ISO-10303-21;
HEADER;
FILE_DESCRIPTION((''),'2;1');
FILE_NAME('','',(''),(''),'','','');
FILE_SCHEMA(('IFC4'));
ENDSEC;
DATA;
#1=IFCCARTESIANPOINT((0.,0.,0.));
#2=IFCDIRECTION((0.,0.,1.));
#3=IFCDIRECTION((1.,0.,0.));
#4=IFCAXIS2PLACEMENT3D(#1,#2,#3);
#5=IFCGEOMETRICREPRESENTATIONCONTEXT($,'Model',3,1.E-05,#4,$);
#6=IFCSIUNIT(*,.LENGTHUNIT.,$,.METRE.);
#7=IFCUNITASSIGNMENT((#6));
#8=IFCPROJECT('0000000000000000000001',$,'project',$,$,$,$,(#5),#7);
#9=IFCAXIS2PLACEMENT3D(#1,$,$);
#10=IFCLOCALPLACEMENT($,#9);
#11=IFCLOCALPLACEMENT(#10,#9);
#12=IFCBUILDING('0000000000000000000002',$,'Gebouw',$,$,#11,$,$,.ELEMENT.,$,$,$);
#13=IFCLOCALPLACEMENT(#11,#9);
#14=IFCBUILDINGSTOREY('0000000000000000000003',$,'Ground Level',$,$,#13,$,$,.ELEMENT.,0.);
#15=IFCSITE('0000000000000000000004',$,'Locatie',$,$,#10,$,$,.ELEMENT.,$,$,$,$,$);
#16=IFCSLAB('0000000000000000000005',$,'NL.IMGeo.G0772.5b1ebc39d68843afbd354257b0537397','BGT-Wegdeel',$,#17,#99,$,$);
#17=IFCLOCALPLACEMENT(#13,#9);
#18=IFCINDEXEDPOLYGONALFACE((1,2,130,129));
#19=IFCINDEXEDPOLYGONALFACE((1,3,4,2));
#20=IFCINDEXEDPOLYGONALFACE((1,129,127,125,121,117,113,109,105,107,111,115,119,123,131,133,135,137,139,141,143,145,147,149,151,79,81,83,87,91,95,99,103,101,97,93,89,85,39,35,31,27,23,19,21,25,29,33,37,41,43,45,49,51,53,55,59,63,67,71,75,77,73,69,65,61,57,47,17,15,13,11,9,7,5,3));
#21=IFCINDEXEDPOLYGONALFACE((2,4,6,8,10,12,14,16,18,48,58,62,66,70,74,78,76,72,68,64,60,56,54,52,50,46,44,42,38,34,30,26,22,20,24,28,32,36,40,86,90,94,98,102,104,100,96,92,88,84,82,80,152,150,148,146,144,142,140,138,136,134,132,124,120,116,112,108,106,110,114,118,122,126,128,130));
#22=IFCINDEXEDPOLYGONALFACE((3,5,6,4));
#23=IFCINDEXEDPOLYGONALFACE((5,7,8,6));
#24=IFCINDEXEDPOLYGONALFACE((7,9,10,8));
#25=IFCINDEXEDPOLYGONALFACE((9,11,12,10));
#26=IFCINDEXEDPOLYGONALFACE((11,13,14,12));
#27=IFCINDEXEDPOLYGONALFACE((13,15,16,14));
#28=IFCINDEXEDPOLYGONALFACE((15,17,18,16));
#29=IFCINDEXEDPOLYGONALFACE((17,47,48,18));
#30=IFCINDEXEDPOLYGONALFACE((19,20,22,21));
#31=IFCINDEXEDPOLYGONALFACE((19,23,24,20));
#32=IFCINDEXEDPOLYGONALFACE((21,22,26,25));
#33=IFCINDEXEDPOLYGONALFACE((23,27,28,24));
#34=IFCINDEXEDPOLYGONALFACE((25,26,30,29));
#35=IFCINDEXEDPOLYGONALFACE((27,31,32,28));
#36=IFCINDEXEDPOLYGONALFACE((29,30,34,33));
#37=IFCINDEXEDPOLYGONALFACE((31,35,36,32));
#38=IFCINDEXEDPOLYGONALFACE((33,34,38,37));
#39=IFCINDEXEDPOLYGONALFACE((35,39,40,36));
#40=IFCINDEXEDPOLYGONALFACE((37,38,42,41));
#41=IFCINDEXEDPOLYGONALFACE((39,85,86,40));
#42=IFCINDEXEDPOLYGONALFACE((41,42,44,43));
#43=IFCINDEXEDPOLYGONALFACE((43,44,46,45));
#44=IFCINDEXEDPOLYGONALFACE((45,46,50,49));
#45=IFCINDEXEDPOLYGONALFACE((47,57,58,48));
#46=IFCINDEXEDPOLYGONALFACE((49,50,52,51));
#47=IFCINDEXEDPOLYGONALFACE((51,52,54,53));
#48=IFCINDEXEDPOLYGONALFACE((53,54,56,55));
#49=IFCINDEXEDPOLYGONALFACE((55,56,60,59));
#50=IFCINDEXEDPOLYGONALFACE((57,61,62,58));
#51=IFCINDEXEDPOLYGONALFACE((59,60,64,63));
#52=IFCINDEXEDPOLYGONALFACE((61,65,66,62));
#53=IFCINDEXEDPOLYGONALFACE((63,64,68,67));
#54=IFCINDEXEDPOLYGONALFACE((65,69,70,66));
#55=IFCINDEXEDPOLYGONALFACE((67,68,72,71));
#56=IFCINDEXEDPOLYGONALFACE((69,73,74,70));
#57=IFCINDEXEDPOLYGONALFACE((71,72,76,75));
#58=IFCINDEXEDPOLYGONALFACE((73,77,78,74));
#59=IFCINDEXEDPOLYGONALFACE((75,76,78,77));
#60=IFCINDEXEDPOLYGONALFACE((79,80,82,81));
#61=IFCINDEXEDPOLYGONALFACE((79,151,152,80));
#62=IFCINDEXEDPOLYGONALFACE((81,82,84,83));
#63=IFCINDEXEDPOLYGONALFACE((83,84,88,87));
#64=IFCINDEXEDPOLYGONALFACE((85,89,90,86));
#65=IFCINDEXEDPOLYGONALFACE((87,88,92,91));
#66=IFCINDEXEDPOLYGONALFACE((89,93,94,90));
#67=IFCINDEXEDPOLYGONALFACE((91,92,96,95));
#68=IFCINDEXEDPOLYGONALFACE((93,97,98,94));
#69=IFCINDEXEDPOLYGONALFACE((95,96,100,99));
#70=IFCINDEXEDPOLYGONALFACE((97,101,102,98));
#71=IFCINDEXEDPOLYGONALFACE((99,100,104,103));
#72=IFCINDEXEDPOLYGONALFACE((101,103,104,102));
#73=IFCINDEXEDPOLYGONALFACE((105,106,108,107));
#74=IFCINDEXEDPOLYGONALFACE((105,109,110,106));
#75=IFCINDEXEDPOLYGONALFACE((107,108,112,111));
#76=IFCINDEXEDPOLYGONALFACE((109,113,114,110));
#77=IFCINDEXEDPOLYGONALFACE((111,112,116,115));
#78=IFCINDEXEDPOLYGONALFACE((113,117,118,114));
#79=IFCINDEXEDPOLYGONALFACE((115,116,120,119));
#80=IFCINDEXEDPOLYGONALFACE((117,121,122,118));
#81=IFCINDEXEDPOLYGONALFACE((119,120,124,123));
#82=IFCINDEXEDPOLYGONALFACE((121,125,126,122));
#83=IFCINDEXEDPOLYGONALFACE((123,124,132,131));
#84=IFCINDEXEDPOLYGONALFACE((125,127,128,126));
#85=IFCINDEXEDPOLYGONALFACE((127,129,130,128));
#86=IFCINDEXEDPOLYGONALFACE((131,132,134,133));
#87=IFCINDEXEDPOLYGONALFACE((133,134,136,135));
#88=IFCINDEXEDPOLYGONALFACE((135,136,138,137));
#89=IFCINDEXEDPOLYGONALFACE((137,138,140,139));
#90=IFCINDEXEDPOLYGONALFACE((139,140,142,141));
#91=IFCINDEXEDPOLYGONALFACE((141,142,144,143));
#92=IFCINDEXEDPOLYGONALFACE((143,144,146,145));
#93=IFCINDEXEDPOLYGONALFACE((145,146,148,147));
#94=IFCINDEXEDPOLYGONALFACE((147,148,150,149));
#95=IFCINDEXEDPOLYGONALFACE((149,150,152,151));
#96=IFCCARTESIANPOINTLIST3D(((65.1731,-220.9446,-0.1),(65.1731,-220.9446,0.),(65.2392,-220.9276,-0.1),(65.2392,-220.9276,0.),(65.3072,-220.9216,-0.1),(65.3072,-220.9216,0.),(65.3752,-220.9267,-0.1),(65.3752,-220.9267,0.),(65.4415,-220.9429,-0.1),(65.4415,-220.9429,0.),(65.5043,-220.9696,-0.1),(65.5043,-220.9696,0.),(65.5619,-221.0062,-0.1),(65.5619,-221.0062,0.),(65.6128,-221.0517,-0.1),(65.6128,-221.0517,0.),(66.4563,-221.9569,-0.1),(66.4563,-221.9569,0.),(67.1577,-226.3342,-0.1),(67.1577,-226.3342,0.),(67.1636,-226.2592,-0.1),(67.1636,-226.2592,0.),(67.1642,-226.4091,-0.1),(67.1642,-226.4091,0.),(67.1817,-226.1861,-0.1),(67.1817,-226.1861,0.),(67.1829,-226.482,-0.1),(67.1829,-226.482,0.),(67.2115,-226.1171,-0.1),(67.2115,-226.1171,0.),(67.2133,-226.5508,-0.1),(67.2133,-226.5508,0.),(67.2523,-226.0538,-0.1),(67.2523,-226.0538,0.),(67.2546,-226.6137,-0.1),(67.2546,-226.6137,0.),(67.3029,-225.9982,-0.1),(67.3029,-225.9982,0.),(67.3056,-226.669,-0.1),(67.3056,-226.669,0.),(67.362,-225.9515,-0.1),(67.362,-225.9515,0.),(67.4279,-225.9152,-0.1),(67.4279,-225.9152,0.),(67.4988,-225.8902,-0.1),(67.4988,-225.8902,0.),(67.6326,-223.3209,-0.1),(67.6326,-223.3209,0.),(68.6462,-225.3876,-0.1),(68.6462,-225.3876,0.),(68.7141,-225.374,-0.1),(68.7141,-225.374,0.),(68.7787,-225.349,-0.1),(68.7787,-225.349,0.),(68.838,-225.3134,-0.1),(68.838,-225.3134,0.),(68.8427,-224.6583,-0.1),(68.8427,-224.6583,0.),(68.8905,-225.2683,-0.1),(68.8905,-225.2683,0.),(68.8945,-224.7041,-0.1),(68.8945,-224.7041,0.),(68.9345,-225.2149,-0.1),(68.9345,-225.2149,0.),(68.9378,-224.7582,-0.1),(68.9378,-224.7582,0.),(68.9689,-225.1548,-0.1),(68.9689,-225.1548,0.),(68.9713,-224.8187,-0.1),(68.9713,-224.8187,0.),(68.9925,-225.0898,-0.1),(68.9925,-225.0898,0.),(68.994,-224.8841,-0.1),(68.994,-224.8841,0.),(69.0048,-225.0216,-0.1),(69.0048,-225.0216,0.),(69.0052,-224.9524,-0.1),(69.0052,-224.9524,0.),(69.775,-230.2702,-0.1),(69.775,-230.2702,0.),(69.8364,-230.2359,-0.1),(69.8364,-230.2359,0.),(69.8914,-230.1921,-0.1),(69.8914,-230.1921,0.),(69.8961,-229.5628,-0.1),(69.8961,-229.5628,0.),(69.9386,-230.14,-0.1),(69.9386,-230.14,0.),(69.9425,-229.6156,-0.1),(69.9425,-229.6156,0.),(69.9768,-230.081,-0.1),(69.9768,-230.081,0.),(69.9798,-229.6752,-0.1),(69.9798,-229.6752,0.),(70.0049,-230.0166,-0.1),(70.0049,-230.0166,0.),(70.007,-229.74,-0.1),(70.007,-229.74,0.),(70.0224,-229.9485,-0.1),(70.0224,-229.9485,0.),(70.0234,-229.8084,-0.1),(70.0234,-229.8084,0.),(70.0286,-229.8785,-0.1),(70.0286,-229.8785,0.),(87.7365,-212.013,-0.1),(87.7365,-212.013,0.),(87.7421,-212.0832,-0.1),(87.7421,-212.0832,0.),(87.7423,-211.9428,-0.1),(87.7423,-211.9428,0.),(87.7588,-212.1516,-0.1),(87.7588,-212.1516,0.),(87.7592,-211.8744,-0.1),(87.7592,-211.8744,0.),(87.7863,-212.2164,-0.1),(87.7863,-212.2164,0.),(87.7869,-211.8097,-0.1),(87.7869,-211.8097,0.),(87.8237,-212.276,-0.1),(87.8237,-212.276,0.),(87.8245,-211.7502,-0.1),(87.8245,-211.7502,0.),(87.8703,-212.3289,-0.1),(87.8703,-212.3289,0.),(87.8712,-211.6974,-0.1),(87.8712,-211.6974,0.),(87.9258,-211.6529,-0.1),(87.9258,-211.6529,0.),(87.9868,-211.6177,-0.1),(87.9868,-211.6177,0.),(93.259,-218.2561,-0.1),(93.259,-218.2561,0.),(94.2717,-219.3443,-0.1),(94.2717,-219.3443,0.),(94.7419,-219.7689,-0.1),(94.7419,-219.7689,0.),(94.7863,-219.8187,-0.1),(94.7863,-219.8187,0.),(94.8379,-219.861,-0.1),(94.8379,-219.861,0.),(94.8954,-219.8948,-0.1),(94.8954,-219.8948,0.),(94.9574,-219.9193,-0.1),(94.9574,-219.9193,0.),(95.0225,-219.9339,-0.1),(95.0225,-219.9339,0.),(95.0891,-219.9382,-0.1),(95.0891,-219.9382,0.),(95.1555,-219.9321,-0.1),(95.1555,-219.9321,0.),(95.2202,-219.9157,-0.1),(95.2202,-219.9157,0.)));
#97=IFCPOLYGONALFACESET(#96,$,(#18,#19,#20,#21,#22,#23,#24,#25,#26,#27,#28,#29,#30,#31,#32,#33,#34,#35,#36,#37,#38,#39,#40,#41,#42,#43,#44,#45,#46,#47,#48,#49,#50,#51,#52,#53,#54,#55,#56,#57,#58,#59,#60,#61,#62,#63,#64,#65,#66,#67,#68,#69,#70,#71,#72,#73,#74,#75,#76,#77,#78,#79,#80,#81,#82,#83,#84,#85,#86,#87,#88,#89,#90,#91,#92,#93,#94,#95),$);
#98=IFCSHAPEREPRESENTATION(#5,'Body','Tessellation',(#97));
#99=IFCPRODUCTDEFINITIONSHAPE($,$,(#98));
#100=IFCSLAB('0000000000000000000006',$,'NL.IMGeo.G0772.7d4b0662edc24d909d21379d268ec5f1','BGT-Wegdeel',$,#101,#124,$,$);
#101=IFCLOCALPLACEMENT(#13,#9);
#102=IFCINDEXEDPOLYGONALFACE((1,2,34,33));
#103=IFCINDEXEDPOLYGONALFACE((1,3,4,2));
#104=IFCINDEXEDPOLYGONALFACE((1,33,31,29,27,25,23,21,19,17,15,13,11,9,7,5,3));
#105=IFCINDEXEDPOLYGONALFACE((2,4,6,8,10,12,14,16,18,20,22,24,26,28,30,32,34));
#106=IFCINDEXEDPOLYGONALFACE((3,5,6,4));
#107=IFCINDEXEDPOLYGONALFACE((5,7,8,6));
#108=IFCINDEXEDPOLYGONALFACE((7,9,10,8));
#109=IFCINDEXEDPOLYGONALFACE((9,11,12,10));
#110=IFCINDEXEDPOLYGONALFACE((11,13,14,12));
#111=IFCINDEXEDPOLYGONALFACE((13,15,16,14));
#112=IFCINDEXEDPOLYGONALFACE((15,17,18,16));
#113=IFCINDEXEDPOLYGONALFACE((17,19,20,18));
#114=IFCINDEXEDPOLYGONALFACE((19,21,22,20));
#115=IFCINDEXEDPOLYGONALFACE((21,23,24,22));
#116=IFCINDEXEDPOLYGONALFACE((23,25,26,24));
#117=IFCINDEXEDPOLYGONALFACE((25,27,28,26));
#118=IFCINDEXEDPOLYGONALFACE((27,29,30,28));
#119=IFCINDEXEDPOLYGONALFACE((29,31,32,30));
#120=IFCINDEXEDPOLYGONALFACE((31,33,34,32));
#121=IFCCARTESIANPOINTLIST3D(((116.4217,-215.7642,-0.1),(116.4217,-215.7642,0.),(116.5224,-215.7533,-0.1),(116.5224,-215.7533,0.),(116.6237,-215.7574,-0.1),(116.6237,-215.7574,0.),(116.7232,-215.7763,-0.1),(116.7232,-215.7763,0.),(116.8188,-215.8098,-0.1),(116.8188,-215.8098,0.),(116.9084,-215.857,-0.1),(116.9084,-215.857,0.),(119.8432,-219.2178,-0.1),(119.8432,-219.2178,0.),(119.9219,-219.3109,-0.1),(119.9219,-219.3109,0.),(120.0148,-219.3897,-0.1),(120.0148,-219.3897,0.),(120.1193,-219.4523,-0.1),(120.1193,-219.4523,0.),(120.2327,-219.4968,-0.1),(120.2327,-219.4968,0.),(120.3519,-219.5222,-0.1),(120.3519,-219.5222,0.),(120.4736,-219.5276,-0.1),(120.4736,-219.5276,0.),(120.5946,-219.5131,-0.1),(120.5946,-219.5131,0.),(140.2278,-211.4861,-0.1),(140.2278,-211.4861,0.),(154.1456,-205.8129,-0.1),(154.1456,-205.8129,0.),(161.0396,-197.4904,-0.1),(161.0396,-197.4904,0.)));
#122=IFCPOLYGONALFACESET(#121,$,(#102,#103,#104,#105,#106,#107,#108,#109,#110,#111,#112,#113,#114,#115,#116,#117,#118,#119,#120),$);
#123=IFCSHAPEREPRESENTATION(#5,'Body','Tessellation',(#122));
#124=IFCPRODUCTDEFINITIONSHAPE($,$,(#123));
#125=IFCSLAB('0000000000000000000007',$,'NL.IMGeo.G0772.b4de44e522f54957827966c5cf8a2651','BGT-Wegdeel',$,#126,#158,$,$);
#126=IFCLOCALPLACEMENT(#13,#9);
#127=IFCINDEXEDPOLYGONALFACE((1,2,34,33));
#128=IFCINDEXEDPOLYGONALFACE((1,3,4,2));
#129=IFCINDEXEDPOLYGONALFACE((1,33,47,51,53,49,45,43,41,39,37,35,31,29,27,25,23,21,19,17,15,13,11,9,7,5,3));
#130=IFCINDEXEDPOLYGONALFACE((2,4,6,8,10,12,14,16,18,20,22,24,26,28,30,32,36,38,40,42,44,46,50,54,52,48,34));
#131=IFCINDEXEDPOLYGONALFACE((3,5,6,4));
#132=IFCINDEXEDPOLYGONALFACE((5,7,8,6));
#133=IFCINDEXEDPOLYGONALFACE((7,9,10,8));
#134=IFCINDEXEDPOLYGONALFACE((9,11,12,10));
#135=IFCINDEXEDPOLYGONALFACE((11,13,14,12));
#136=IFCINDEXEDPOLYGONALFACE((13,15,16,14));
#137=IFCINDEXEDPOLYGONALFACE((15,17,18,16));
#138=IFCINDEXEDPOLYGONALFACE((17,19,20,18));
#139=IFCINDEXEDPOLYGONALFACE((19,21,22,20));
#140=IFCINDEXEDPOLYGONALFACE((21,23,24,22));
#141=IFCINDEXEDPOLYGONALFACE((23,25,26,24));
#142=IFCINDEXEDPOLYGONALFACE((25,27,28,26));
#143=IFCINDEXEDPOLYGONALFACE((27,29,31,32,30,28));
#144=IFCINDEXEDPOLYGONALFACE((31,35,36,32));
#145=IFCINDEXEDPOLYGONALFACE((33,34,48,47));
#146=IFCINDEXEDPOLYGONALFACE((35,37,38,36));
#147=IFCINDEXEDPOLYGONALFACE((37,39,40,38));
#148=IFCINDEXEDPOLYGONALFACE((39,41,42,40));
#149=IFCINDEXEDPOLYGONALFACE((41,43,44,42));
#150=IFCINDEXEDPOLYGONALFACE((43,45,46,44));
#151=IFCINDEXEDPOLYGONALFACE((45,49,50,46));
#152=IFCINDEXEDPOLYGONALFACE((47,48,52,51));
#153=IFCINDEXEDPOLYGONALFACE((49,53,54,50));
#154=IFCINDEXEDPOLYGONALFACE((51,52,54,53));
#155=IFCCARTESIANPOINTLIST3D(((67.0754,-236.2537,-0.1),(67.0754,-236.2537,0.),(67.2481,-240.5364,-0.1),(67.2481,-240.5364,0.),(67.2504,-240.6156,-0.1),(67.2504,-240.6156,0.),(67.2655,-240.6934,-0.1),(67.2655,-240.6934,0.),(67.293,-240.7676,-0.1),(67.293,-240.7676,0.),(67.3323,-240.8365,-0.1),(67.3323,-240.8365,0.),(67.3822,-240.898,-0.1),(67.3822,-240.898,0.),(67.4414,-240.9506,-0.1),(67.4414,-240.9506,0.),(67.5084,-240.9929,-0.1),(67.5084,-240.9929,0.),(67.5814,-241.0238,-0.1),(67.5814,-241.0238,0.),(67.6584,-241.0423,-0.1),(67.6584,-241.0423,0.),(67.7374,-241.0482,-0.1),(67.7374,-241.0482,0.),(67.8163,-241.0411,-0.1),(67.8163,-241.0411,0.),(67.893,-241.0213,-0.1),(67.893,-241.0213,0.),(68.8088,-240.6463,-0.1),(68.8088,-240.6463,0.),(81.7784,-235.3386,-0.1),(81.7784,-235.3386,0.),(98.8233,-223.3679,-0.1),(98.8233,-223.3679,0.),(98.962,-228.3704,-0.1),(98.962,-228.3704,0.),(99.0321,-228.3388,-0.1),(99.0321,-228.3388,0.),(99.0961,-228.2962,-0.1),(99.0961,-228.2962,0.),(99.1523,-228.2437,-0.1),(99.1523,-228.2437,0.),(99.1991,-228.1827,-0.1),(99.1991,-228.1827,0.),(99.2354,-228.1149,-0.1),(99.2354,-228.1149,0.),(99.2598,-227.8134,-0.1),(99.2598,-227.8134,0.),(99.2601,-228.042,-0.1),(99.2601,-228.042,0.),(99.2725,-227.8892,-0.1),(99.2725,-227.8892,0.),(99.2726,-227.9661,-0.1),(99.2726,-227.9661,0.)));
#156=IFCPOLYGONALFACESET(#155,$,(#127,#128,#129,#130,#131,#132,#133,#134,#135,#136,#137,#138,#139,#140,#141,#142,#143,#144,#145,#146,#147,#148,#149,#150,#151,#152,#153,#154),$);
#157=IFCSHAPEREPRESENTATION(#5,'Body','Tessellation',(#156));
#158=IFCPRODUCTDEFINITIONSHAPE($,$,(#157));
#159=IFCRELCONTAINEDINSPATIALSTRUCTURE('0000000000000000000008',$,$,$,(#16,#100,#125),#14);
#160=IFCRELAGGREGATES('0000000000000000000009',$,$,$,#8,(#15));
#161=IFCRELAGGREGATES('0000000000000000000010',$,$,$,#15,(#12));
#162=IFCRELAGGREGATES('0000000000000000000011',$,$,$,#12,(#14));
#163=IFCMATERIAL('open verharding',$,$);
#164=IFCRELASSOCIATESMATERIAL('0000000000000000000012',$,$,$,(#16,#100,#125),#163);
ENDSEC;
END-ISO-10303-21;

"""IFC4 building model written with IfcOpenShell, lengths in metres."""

from ifc_helpers import new_model, si_unit, frame, origin, origin_with_axes, place, context, project, spatial, polyline, outline, extrude, material, element, save


model = new_model("IFC4")

# Units and contexts
model_context = context("Model", 3, precision=1e-05, world=origin_with_axes())
ifc_project = project(units=[si_unit("LENGTHUNIT", "METRE")], contexts=[model_context])

# Site, building, storey
site_placement = place(None, origin())
site = spatial("IfcSite", under=ifc_project, at=site_placement, Name="Locatie", CompositionType="ELEMENT")
building_placement = place(site_placement, origin())
building = spatial("IfcBuilding", under=site, at=building_placement, Name="Gebouw", CompositionType="ELEMENT")
storey_placement = place(building_placement, origin())
storey = spatial("IfcBuildingStorey", under=building, at=storey_placement, Name="Ground Level", CompositionType="ELEMENT", Elevation=0.0)

# Slabs
ifc_material_1 = material(Name="open verharding")
slab_1_placement = place(storey_placement, origin())
element("IfcSlab", 1, at=slab_1_placement, inside=storey, material=ifc_material_1, Name="NL.IMGeo.G0772.5b1ebc39d68843afbd354257b0537397", Description="BGT-Wegdeel", context=model_context, shape_type="SweptSolid", body=[
    extrude(outline(polyline([(87.9868, -211.6177), (87.9258, -211.6529), (87.8712, -211.6974), (87.8245, -211.7502), (87.7869, -211.8097), (87.7592, -211.8744), (87.7423, -211.9428), (87.7365, -212.013), (87.7421, -212.0832), (87.7588, -212.1516), (87.7863, -212.2164), (87.8237, -212.276), (87.8703, -212.3289), (93.259, -218.2561), (94.2717, -219.3443), (94.7419, -219.7689), (94.7863, -219.8187), (94.8379, -219.861), (94.8954, -219.8948), (94.9574, -219.9193), (95.0225, -219.9339), (95.0891, -219.9382), (95.1555, -219.9321), (95.2202, -219.9157), (69.775, -230.2702), (69.8364, -230.2359), (69.8914, -230.1921), (69.9386, -230.14), (69.9768, -230.081), (70.0049, -230.0166), (70.0224, -229.9485), (70.0286, -229.8785), (70.0234, -229.8084), (70.007, -229.74), (69.9798, -229.6752), (69.9425, -229.6156), (69.8961, -229.5628), (67.3056, -226.669), (67.2546, -226.6137), (67.2133, -226.5508), (67.1829, -226.482), (67.1642, -226.4091), (67.1577, -226.3342), (67.1636, -226.2592), (67.1817, -226.1861), (67.2115, -226.1171), (67.2523, -226.0538), (67.3029, -225.9982), (67.362, -225.9515), (67.4279, -225.9152), (67.4988, -225.8902), (68.6462, -225.3876), (68.7141, -225.374), (68.7787, -225.349), (68.838, -225.3134), (68.8905, -225.2683), (68.9345, -225.2149), (68.9689, -225.1548), (68.9925, -225.0898), (69.0048, -225.0216), (69.0052, -224.9524), (68.994, -224.8841), (68.9713, -224.8187), (68.9378, -224.7582), (68.8945, -224.7041), (68.8427, -224.6583), (67.6326, -223.3209), (66.4563, -221.9569), (65.6128, -221.0517), (65.5619, -221.0062), (65.5043, -220.9696), (65.4415, -220.9429), (65.3752, -220.9267), (65.3072, -220.9216), (65.2392, -220.9276), (65.1731, -220.9446), (87.9868, -211.6177)])), frame((0.0, 0.0, -0.1), z_axis=(0.0, 0.0, 1.0), x_axis=(1.0, 0.0, 0.0)), (0.0, 0.0, 1.0), 0.1),
])
slab_2_placement = place(storey_placement, origin())
element("IfcSlab", 2, at=slab_2_placement, inside=storey, material=ifc_material_1, Name="NL.IMGeo.G0772.7d4b0662edc24d909d21379d268ec5f1", Description="BGT-Wegdeel", context=model_context, shape_type="SweptSolid", body=[
    extrude(outline(polyline([(140.2278, -211.4861), (120.5946, -219.5131), (120.4736, -219.5276), (120.3519, -219.5222), (120.2327, -219.4968), (120.1193, -219.4523), (120.0148, -219.3897), (119.9219, -219.3109), (119.8432, -219.2178), (116.9084, -215.857), (116.8188, -215.8098), (116.7232, -215.7763), (116.6237, -215.7574), (116.5224, -215.7533), (116.4217, -215.7642), (161.0396, -197.4904), (154.1456, -205.8129), (140.2278, -211.4861)])), frame((0.0, 0.0, -0.1), z_axis=(0.0, 0.0, 1.0), x_axis=(1.0, 0.0, 0.0)), (0.0, 0.0, 1.0), 0.1),
])
slab_3_placement = place(storey_placement, origin())
element("IfcSlab", 3, at=slab_3_placement, inside=storey, material=ifc_material_1, Name="NL.IMGeo.G0772.b4de44e522f54957827966c5cf8a2651", Description="BGT-Wegdeel", context=model_context, shape_type="SweptSolid", body=[
    extrude(outline(polyline([(98.8233, -223.3679), (99.2598, -227.8134), (99.2725, -227.8892), (99.2726, -227.9661), (99.2601, -228.042), (99.2354, -228.1149), (99.1991, -228.1827), (99.1523, -228.2437), (99.0961, -228.2962), (99.0321, -228.3388), (98.962, -228.3704), (81.7784, -235.3386), (68.8088, -240.6463), (67.893, -241.0213), (67.8163, -241.0411), (67.7374, -241.0482), (67.6584, -241.0423), (67.5814, -241.0238), (67.5084, -240.9929), (67.4414, -240.9506), (67.3822, -240.898), (67.3323, -240.8365), (67.293, -240.7676), (67.2655, -240.6934), (67.2504, -240.6156), (67.2481, -240.5364), (67.0754, -236.2537), (98.8233, -223.3679)])), frame((0.0, 0.0, -0.1), z_axis=(0.0, 0.0, 1.0), x_axis=(1.0, 0.0, 0.0)), (0.0, 0.0, 1.0), 0.1),
])

save(model, "model.ifc")
